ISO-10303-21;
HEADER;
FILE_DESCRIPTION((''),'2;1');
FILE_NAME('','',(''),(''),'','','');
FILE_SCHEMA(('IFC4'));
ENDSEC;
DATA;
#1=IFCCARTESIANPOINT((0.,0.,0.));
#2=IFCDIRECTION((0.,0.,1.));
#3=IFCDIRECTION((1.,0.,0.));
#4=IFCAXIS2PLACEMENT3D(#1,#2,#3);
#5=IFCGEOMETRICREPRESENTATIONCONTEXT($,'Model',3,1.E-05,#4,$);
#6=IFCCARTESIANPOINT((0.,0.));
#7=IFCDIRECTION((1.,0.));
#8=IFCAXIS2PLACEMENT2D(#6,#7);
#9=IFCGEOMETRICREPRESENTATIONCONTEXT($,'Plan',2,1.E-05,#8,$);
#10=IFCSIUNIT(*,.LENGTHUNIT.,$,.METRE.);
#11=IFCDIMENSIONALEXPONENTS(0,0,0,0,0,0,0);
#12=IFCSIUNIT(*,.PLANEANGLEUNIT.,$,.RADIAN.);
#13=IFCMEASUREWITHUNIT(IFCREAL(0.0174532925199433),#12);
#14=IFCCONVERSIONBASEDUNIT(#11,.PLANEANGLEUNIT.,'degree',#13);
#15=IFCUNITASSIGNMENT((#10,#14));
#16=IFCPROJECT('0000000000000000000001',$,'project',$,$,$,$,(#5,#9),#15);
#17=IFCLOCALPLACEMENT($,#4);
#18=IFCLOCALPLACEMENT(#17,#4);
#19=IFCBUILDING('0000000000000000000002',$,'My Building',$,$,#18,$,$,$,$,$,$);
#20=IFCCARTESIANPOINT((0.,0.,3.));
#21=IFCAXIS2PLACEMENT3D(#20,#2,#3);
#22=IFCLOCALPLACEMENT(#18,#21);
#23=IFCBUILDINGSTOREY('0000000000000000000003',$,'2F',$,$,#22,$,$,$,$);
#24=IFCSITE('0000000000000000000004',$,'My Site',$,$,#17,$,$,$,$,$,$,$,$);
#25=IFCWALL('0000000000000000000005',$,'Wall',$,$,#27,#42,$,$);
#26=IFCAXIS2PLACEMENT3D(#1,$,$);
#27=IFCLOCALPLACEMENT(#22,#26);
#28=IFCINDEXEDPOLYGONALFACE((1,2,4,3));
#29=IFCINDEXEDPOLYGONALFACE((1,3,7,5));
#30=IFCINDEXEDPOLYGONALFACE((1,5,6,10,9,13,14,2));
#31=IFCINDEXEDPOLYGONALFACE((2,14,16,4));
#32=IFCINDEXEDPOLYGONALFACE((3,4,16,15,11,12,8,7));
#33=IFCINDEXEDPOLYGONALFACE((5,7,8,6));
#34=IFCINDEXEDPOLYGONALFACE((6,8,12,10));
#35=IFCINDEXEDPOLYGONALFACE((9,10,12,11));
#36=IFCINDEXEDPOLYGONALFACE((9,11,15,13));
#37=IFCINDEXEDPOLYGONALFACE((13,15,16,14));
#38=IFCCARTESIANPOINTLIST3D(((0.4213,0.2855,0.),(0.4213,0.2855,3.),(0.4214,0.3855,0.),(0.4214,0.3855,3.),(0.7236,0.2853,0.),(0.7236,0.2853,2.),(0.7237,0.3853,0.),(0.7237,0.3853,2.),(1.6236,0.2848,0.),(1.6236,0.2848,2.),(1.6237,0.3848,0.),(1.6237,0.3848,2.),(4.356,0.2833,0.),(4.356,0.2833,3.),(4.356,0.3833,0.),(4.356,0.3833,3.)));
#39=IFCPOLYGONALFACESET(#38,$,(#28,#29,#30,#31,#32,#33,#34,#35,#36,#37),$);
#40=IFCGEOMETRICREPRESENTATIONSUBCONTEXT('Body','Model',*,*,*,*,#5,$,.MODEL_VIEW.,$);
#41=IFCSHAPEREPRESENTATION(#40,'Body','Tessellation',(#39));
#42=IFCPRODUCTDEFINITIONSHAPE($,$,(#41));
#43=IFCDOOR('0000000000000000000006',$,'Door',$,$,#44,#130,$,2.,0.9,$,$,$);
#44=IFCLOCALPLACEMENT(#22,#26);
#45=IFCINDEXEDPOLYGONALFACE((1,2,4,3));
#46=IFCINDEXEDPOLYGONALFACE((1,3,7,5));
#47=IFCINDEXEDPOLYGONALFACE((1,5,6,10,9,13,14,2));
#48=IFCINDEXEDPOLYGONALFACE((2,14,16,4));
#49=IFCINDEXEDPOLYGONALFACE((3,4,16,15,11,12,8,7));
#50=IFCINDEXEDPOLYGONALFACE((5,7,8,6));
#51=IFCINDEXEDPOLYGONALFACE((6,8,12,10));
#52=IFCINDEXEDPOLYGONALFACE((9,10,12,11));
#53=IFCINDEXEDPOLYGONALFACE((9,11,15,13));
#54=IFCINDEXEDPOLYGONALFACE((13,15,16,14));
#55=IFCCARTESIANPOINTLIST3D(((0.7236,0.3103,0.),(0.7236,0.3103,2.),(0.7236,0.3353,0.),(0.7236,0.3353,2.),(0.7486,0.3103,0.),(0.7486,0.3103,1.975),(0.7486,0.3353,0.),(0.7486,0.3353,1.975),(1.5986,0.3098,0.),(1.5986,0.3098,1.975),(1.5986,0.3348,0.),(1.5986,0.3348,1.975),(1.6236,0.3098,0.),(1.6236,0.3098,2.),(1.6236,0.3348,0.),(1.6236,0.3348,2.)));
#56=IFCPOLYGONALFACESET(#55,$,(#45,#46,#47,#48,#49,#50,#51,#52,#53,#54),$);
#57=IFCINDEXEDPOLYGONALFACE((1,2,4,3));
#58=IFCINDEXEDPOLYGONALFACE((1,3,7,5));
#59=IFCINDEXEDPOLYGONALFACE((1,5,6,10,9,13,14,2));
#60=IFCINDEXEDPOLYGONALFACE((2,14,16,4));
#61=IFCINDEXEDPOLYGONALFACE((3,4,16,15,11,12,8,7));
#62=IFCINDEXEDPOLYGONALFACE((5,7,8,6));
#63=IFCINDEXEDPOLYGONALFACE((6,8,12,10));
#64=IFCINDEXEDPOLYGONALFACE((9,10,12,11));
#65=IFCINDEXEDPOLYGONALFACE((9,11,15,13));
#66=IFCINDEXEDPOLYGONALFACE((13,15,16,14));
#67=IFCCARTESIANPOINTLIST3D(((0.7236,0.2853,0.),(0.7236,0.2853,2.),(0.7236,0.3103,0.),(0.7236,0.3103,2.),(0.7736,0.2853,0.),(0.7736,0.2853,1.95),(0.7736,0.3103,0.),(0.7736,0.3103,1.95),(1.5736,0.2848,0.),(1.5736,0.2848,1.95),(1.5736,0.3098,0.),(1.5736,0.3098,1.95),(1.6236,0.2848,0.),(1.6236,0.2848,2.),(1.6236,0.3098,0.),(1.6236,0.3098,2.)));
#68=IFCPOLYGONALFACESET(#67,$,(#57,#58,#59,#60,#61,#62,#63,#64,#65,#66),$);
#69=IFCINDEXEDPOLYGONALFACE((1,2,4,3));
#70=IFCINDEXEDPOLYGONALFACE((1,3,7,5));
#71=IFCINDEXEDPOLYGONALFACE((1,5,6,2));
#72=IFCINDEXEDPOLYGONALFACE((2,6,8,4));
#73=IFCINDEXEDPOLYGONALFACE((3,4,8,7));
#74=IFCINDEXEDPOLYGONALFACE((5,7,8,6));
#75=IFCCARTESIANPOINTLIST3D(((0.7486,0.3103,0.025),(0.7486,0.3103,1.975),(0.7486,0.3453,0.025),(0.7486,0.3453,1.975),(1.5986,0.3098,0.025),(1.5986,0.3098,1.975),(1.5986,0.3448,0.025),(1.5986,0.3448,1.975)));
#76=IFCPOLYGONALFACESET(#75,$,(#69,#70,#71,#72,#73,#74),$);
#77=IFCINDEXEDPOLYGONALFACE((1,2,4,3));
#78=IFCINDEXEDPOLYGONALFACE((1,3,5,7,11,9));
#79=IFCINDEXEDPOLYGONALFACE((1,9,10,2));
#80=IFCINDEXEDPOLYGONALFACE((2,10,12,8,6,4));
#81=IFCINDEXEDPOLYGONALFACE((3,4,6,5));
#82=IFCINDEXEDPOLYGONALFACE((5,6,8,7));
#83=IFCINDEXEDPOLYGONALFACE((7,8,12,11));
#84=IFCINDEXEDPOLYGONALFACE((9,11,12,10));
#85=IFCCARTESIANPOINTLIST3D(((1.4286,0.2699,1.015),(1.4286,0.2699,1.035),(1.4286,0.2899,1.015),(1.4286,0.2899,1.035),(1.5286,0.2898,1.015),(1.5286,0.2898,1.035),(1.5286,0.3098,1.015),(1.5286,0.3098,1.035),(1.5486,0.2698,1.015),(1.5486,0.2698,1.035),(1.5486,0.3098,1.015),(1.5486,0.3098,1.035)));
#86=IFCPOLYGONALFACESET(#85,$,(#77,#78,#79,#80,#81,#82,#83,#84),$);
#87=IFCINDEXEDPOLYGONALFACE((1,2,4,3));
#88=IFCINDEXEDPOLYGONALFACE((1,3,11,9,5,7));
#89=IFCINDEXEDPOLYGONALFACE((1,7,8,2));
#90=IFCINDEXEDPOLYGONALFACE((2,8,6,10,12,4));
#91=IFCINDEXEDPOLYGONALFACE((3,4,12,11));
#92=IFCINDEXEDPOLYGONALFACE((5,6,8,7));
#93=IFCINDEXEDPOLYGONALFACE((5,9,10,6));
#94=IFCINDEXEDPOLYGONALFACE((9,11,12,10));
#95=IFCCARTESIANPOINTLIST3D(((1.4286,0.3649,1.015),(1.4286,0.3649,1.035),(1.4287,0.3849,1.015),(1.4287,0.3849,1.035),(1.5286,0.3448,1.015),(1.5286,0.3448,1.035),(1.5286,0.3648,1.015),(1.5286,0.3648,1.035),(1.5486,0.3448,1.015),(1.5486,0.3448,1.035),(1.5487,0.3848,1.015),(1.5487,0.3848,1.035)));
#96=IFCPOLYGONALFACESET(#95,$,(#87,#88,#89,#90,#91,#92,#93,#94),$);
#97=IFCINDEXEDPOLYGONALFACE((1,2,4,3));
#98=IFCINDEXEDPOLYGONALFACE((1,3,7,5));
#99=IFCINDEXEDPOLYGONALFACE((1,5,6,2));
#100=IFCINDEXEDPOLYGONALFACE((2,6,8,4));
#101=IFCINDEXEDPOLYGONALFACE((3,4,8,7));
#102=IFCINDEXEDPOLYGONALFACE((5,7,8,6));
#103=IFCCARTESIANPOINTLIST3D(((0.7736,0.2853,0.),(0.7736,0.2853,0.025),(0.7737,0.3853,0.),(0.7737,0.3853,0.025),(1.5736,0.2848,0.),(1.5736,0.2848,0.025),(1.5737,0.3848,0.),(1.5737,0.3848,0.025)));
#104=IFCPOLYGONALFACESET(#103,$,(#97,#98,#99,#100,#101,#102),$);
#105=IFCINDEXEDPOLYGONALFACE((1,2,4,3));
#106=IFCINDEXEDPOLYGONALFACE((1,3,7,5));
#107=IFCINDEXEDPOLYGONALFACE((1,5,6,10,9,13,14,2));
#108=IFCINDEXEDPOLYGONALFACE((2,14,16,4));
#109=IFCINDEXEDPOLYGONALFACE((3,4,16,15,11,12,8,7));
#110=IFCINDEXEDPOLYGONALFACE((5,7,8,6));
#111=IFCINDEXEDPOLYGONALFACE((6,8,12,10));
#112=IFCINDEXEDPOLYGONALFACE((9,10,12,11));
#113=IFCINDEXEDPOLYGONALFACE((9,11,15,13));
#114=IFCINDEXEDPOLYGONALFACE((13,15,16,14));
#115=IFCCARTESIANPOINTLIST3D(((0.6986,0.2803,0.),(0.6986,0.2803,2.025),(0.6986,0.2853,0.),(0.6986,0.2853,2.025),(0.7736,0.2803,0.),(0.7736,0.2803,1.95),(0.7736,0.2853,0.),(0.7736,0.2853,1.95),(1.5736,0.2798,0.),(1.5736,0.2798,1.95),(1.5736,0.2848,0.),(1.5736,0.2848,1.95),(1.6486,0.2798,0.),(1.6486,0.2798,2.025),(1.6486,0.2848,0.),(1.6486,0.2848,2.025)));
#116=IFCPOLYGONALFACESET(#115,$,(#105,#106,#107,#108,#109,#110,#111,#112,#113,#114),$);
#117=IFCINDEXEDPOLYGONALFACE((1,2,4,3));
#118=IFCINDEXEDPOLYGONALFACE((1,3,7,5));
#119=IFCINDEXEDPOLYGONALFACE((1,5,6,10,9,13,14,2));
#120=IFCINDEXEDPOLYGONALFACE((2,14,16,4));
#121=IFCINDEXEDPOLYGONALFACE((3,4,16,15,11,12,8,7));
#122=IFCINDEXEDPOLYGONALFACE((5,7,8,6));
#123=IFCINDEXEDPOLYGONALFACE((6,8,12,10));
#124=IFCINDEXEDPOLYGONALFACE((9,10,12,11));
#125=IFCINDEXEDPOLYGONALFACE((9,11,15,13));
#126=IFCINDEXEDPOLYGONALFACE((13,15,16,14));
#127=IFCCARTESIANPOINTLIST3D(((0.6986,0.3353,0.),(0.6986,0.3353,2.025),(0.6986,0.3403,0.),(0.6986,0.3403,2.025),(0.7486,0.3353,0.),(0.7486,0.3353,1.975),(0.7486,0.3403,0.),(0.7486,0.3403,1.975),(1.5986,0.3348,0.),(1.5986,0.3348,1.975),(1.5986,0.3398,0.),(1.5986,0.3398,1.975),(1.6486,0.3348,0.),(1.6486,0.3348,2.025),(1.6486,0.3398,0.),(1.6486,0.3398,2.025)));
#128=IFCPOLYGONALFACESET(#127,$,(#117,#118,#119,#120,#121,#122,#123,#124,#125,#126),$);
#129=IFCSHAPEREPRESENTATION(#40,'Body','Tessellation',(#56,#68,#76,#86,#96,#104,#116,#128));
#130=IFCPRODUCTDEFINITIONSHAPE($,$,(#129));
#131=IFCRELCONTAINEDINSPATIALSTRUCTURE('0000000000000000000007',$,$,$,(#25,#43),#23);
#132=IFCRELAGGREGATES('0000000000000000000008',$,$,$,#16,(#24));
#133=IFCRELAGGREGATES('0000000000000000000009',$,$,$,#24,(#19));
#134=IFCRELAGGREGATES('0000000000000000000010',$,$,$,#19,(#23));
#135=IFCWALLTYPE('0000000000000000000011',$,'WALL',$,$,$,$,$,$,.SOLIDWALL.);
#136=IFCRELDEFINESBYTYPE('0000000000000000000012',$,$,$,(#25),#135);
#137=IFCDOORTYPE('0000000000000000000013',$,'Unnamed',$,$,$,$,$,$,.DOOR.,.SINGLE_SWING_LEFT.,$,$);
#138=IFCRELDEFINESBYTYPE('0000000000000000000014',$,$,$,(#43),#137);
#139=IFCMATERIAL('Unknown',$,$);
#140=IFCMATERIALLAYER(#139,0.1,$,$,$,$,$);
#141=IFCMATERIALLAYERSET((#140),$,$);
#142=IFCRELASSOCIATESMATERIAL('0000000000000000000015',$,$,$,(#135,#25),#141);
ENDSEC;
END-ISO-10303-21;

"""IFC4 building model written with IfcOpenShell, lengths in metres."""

from ifc_helpers import new_model, entity, si_unit, converted_unit, frame, origin_with_axes, origin_2d_with_axis, place, context, subcontext, project, spatial, line, indexed_curve, outline, extrude, shape, source, transform, mapped, material, layer, layer_set, layer_usage, type_object, type_shapes, element, fill, save


model = new_model("IFC4")

# Units and contexts
model_context = context("Model", 3, precision=1e-05, world=origin_with_axes())
plan_context = context("Plan", 2, precision=1e-05, world=origin_2d_with_axis())
body_context_1 = subcontext(model_context, "Body", "Model", "MODEL_VIEW")
body_context_2 = subcontext(plan_context, "Body", "Plan", "PLAN_VIEW")
ifc_project = project(units=[si_unit("LENGTHUNIT", "METRE"), converted_unit("PLANEANGLEUNIT", "degree", entity("IfcReal", 0.0174532925199433), si_unit("PLANEANGLEUNIT", "RADIAN"), dimensions=[0, 0, 0, 0, 0, 0, 0])], contexts=[model_context, plan_context])

# Site, building, storey
site_placement = place(None, origin_with_axes())
site = spatial("IfcSite", under=ifc_project, at=site_placement, Name="My Site")
building_placement = place(site_placement, origin_with_axes())
building = spatial("IfcBuilding", under=site, at=building_placement, Name="My Building")
storey_placement = place(building_placement, frame((0.0, 0.0, 3.0), z_axis=(0.0, 0.0, 1.0), x_axis=(1.0, 0.0, 0.0)))
storey = spatial("IfcBuildingStorey", under=building, at=storey_placement, Name="2F")

# Shared definitions
ifc_material = material(Name="Unknown")

# Shared definitions
ifc_layer = layer(ifc_material, 0.1)
ifc_layer_set = layer_set([ifc_layer])
wall_type = type_object("IfcWallType", Name="WALL", PredefinedType="SOLIDWALL", material=ifc_layer_set)

# Shared definitions
shared_shape_1 = source(origin_with_axes(), body_context_1, "Body", "SweptSolid", [
    extrude(outline(indexed_curve([(0.0, 0.0), (0.9, 0.0), (0.9, 2.0), (0.0, 2.0)], segments=[line(1, 2, 3, 4, 1)])), frame((0.0, -0.6, 0.0), z_axis=(0.0, -1.0, 0.0), x_axis=(1.0, 0.0, 0.0)), (0.0, 0.0, -1.0), 1.2),
])
door_type = type_object("IfcDoorType", Name="Unnamed", OperationType="SINGLE_SWING_LEFT", PredefinedType="DOOR")
shared_shape_2 = source(origin_with_axes(), body_context_1, "Body", "SweptSolid", [
    extrude(outline(indexed_curve([(0.0, 0.0), (0.0, 2.0), (0.9, 2.0), (0.9, 0.0), (0.875, 0.0), (0.875, 1.975), (0.025, 1.975), (0.025, 0.0)], segments=[line(1, 2, 3, 4, 5, 6, 7, 8, 1)])), frame((0.0, 0.025, 0.0), z_axis=(0.0, -1.0, 0.0), x_axis=(1.0, 0.0, 0.0)), (0.0, 0.0, -1.0), 0.025),
    extrude(outline(indexed_curve([(0.0, 0.0), (0.0, 2.0), (0.9, 2.0), (0.9, 0.0), (0.85, 0.0), (0.85, 1.95), (0.05, 1.95), (0.05, 0.0)], segments=[line(1, 2, 3, 4, 5, 6, 7, 8, 1)])), frame((0.0, 0.0, 0.0), z_axis=(0.0, -1.0, 0.0), x_axis=(1.0, 0.0, 0.0)), (0.0, 0.0, -1.0), 0.025),
    extrude(outline(indexed_curve([(0.0, 0.0), (0.85, 0.0), (0.85, 0.035), (0.0, 0.035)], segments=[line(1, 2, 3, 4, 1)])), frame((0.025, 0.025, 0.025), z_axis=(0.0, 0.0, 1.0), x_axis=(1.0, 0.0, 0.0)), (0.0, 0.0, 1.0), 1.95),
    extrude(outline(indexed_curve([(0.0, 0.0), (0.0, -0.04), (-0.12, -0.04), (-0.12, -0.02), (-0.02, -0.02), (-0.02, 0.0)], segments=[line(1, 2, 3, 4, 5, 6, 1)])), frame((0.825, 0.025, 1.015), z_axis=(0.0, 0.0, 1.0), x_axis=(1.0, 0.0, 0.0)), (0.0, 0.0, 1.0), 0.02),
    extrude(outline(indexed_curve([(0.0, 0.0), (0.0, 0.04), (-0.12, 0.04), (-0.12, 0.02), (-0.02, 0.02), (-0.02, 0.0)], segments=[line(1, 2, 3, 4, 5, 6, 1)])), frame((0.825, 0.06, 1.015), z_axis=(0.0, 0.0, 1.0), x_axis=(1.0, 0.0, 0.0)), (0.0, 0.0, 1.0), 0.02),
    extrude(outline(indexed_curve([(0.0, 0.0), (0.8, 0.0), (0.8, 0.1), (0.0, 0.1)], segments=[line(1, 2, 3, 4, 1)])), frame((0.05, 0.0, 0.0), z_axis=(0.0, 0.0, 1.0), x_axis=(1.0, 0.0, 0.0)), (0.0, 0.0, 1.0), 0.025),
    extrude(outline(indexed_curve([(0.0, 0.0), (0.0, 2.025), (0.95, 2.025), (0.95, 0.0), (0.875, 0.0), (0.875, 1.95), (0.075, 1.95), (0.075, 0.0)], segments=[line(1, 2, 3, 4, 5, 6, 7, 8, 1)])), frame((-0.025, -0.005, 0.0), z_axis=(0.0, -1.0, 0.0), x_axis=(1.0, 0.0, 0.0)), (0.0, 0.0, -1.0), 0.005),
    extrude(outline(indexed_curve([(0.0, 0.0), (0.0, 2.025), (0.95, 2.025), (0.95, 0.0), (0.9, 0.0), (0.9, 1.975), (0.05, 1.975), (0.05, 0.0)], segments=[line(1, 2, 3, 4, 5, 6, 7, 8, 1)])), frame((-0.025, 0.05, 0.0), z_axis=(0.0, -1.0, 0.0), x_axis=(1.0, 0.0, 0.0)), (0.0, 0.0, -1.0), 0.005),
])
shared_shape_3 = source(origin_with_axes(), body_context_2, "Body", "Curve2D", [
    entity("IfcIndexedPolyCurve", entity("IfcCartesianPointList2D", [[0.0, 0.0], [0.0, 0.05], [0.025, 0.05], [0.025, 0.025], [0.05, 0.025], [0.05, 0.0]]), [entity("IfcLineIndex", [1, 2, 3, 4, 5, 6, 1])]),
    entity("IfcIndexedPolyCurve", entity("IfcCartesianPointList2D", [[0.9, 0.0], [0.9, 0.05], [0.875, 0.05], [0.875, 0.025], [0.85, 0.025], [0.85, 0.0]]), [entity("IfcLineIndex", [1, 2, 3, 4, 5, 6, 1])]),
    entity("IfcTrimmedCurve", entity("IfcEllipse", entity("IfcAxis2Placement2D", entity("IfcCartesianPoint", [0.06, 0.05]), entity("IfcDirection", [1.0, 0.0])), 0.815, 0.85), [entity("IfcCartesianPoint", [0.875, 0.05])], [entity("IfcCartesianPoint", [0.06, 0.9])], True, "CARTESIAN"),
    entity("IfcIndexedPolyCurve", entity("IfcCartesianPointList2D", [[0.025, 0.05], [0.06, 0.05], [0.06, 0.9], [0.025, 0.9]]), [entity("IfcLineIndex", [1, 2, 3, 4, 1])]),
])
type_shapes(door_type, [shared_shape_2, shared_shape_3])

# Wall, opening, door
ifc_layer_usage_1 = layer_usage(ifc_layer_set, "AXIS2", "POSITIVE", 0.0)
wall_1_placement = place(storey_placement, frame((0.4213, 0.2855, 0.0), z_axis=(0.0, 0.0, 1.0), x_axis=(1.0, -0.000561, 0.0)))
wall_1 = element("IfcWall", 1, at=wall_1_placement, inside=storey, type_object=wall_type, material=ifc_layer_usage_1, Name="Wall", context=body_context_1, shape_type="SweptSolid", body=[
    extrude(outline(indexed_curve([(0.0, 0.0), (0.0, 0.1), (3.9347, 0.1), (3.9347, 0.0)], segments=[line(1, 2, 3, 4, 1)])), origin_with_axes(), (0.0, 0.0, 1.0), 3.0),
])
opening_1_placement = place(wall_1_placement, frame((0.3023, 0.0, 0.0), z_axis=(0.0, 0.0, 1.0), x_axis=(1.0, 0.0, 0.0)))
opening_1 = element("IfcOpeningElement", 2, at=opening_1_placement, cuts=wall_1, PredefinedType="OPENING", context=body_context_1, shape_type="MappedRepresentation", body=[
    mapped(shared_shape_1, transform((0.0, 0.0, 0.0), x_axis=(1.0, 0.0, 0.0), y_axis=(0.0, 1.0, 0.0), z_axis=(0.0, 0.0, 1.0), scale=1.0)),
])
door_1_placement = place(opening_1_placement, frame((0.0, 0.0, 0.0), z_axis=(0.0, 0.0, 1.0), x_axis=(1.0, 0.0, 0.0)))
door_1 = element("IfcDoor", 3, at=door_1_placement, inside=storey, type_object=door_type, Name="Door", OverallHeight=2.0, OverallWidth=0.9, shapes=[
    shape(body_context_1, "Body", "MappedRepresentation", [mapped(shared_shape_2, transform((0.0, 0.0, 0.0), x_axis=(1.0, 0.0, 0.0), y_axis=(0.0, 1.0, 0.0), z_axis=(0.0, 0.0, 1.0), scale=1.0))]),
    shape(body_context_2, "Body", "MappedRepresentation", [mapped(shared_shape_3, transform((0.0, 0.0, 0.0), x_axis=(1.0, 0.0, 0.0), y_axis=(0.0, 1.0, 0.0), z_axis=(0.0, 0.0, 1.0), scale=1.0))]),
])
fill(opening_1, door_1)

save(model, "model.ifc")
